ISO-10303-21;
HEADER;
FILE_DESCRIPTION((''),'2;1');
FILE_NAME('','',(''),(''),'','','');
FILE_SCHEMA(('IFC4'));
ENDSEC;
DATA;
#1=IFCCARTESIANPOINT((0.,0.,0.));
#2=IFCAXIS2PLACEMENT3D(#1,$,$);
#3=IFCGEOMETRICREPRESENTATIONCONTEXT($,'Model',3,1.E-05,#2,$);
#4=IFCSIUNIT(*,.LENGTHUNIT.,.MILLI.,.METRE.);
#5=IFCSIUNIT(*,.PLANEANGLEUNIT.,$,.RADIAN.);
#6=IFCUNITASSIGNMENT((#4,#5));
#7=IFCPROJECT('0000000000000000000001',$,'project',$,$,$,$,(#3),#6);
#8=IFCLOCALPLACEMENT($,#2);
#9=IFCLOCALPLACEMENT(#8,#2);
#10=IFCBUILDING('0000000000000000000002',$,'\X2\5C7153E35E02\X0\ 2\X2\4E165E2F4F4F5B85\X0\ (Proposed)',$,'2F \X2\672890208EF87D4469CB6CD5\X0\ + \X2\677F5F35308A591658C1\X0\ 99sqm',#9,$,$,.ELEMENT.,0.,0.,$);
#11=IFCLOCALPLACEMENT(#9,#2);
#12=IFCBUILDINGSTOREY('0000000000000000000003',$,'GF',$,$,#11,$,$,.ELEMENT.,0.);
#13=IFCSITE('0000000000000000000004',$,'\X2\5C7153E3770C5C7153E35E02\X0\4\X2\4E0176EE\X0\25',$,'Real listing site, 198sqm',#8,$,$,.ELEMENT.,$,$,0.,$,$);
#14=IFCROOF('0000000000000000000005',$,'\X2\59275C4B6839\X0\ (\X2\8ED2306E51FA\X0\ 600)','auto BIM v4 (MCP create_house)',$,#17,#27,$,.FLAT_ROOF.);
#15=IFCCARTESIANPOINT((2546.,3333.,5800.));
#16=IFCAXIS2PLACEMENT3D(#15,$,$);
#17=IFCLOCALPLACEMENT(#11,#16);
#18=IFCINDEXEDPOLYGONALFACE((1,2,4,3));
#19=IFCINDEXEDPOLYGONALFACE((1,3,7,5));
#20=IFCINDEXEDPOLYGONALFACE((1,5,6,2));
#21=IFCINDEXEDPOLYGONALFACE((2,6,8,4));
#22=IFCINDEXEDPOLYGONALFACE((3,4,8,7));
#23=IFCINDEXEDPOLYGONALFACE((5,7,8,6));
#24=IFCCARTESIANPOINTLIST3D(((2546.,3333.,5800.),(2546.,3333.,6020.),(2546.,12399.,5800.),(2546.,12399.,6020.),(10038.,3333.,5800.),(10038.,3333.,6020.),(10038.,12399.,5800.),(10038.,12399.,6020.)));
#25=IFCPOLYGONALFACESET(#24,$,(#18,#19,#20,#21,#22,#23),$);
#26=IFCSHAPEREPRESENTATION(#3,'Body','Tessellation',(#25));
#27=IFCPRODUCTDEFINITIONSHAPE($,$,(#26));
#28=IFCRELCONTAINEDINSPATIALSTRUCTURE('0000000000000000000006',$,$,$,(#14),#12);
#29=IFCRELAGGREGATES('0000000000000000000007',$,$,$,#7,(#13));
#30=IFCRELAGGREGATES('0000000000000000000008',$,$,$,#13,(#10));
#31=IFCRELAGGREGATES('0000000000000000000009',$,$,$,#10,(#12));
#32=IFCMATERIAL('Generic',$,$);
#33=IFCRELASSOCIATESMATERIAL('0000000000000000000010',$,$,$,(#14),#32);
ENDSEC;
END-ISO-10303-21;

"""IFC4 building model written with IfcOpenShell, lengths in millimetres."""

from ifc_helpers import new_model, si_unit, frame, frame_2d, origin, place, context, project, spatial, rectangle, extrude, material, element, save


model = new_model("IFC4")

# Units and contexts
model_context = context("Model", 3, precision=1e-05, world=origin())
ifc_project = project(units=[si_unit("LENGTHUNIT", "METRE", prefix="MILLI"), si_unit("PLANEANGLEUNIT", "RADIAN")], contexts=[model_context])

# Site, building, storey
site_placement = place(None, origin())
site = spatial("IfcSite", under=ifc_project, at=site_placement, Name="山口県山口市4丁目25", ObjectType="Real listing site, 198sqm", CompositionType="ELEMENT", RefElevation=0.0)
building_placement = place(site_placement, origin())
building = spatial("IfcBuilding", under=site, at=building_placement, Name="山口市 2世帯住宅 (Proposed)", ObjectType="2F 木造軸組構法 + 板張り外壁 99sqm", CompositionType="ELEMENT", ElevationOfRefHeight=0.0, ElevationOfTerrain=0.0)
storey_placement = place(building_placement, origin())
storey = spatial("IfcBuildingStorey", under=building, at=storey_placement, Name="GF", CompositionType="ELEMENT", Elevation=0.0)

# Shared definitions
ifc_material = material(Name="Generic")

# Roof
roof_placement = place(storey_placement, frame((2546.0, 3333.0, 5800.0)))
element("IfcRoof", 1, at=roof_placement, inside=storey, material=ifc_material, Name="大屋根 (軒の出 600)", Description="auto BIM v4 (MCP create_house)", PredefinedType="FLAT_ROOF", context=model_context, shape_type="SweptSolid", body=[
    extrude(rectangle(XDim=7492.0, YDim=9066.0, at=frame_2d((3746.0, 4533.0))), frame((2546.0, 3333.0, 5800.0)), (0.0, 0.0, 1.0), 220.0),
])

save(model, "model.ifc")
